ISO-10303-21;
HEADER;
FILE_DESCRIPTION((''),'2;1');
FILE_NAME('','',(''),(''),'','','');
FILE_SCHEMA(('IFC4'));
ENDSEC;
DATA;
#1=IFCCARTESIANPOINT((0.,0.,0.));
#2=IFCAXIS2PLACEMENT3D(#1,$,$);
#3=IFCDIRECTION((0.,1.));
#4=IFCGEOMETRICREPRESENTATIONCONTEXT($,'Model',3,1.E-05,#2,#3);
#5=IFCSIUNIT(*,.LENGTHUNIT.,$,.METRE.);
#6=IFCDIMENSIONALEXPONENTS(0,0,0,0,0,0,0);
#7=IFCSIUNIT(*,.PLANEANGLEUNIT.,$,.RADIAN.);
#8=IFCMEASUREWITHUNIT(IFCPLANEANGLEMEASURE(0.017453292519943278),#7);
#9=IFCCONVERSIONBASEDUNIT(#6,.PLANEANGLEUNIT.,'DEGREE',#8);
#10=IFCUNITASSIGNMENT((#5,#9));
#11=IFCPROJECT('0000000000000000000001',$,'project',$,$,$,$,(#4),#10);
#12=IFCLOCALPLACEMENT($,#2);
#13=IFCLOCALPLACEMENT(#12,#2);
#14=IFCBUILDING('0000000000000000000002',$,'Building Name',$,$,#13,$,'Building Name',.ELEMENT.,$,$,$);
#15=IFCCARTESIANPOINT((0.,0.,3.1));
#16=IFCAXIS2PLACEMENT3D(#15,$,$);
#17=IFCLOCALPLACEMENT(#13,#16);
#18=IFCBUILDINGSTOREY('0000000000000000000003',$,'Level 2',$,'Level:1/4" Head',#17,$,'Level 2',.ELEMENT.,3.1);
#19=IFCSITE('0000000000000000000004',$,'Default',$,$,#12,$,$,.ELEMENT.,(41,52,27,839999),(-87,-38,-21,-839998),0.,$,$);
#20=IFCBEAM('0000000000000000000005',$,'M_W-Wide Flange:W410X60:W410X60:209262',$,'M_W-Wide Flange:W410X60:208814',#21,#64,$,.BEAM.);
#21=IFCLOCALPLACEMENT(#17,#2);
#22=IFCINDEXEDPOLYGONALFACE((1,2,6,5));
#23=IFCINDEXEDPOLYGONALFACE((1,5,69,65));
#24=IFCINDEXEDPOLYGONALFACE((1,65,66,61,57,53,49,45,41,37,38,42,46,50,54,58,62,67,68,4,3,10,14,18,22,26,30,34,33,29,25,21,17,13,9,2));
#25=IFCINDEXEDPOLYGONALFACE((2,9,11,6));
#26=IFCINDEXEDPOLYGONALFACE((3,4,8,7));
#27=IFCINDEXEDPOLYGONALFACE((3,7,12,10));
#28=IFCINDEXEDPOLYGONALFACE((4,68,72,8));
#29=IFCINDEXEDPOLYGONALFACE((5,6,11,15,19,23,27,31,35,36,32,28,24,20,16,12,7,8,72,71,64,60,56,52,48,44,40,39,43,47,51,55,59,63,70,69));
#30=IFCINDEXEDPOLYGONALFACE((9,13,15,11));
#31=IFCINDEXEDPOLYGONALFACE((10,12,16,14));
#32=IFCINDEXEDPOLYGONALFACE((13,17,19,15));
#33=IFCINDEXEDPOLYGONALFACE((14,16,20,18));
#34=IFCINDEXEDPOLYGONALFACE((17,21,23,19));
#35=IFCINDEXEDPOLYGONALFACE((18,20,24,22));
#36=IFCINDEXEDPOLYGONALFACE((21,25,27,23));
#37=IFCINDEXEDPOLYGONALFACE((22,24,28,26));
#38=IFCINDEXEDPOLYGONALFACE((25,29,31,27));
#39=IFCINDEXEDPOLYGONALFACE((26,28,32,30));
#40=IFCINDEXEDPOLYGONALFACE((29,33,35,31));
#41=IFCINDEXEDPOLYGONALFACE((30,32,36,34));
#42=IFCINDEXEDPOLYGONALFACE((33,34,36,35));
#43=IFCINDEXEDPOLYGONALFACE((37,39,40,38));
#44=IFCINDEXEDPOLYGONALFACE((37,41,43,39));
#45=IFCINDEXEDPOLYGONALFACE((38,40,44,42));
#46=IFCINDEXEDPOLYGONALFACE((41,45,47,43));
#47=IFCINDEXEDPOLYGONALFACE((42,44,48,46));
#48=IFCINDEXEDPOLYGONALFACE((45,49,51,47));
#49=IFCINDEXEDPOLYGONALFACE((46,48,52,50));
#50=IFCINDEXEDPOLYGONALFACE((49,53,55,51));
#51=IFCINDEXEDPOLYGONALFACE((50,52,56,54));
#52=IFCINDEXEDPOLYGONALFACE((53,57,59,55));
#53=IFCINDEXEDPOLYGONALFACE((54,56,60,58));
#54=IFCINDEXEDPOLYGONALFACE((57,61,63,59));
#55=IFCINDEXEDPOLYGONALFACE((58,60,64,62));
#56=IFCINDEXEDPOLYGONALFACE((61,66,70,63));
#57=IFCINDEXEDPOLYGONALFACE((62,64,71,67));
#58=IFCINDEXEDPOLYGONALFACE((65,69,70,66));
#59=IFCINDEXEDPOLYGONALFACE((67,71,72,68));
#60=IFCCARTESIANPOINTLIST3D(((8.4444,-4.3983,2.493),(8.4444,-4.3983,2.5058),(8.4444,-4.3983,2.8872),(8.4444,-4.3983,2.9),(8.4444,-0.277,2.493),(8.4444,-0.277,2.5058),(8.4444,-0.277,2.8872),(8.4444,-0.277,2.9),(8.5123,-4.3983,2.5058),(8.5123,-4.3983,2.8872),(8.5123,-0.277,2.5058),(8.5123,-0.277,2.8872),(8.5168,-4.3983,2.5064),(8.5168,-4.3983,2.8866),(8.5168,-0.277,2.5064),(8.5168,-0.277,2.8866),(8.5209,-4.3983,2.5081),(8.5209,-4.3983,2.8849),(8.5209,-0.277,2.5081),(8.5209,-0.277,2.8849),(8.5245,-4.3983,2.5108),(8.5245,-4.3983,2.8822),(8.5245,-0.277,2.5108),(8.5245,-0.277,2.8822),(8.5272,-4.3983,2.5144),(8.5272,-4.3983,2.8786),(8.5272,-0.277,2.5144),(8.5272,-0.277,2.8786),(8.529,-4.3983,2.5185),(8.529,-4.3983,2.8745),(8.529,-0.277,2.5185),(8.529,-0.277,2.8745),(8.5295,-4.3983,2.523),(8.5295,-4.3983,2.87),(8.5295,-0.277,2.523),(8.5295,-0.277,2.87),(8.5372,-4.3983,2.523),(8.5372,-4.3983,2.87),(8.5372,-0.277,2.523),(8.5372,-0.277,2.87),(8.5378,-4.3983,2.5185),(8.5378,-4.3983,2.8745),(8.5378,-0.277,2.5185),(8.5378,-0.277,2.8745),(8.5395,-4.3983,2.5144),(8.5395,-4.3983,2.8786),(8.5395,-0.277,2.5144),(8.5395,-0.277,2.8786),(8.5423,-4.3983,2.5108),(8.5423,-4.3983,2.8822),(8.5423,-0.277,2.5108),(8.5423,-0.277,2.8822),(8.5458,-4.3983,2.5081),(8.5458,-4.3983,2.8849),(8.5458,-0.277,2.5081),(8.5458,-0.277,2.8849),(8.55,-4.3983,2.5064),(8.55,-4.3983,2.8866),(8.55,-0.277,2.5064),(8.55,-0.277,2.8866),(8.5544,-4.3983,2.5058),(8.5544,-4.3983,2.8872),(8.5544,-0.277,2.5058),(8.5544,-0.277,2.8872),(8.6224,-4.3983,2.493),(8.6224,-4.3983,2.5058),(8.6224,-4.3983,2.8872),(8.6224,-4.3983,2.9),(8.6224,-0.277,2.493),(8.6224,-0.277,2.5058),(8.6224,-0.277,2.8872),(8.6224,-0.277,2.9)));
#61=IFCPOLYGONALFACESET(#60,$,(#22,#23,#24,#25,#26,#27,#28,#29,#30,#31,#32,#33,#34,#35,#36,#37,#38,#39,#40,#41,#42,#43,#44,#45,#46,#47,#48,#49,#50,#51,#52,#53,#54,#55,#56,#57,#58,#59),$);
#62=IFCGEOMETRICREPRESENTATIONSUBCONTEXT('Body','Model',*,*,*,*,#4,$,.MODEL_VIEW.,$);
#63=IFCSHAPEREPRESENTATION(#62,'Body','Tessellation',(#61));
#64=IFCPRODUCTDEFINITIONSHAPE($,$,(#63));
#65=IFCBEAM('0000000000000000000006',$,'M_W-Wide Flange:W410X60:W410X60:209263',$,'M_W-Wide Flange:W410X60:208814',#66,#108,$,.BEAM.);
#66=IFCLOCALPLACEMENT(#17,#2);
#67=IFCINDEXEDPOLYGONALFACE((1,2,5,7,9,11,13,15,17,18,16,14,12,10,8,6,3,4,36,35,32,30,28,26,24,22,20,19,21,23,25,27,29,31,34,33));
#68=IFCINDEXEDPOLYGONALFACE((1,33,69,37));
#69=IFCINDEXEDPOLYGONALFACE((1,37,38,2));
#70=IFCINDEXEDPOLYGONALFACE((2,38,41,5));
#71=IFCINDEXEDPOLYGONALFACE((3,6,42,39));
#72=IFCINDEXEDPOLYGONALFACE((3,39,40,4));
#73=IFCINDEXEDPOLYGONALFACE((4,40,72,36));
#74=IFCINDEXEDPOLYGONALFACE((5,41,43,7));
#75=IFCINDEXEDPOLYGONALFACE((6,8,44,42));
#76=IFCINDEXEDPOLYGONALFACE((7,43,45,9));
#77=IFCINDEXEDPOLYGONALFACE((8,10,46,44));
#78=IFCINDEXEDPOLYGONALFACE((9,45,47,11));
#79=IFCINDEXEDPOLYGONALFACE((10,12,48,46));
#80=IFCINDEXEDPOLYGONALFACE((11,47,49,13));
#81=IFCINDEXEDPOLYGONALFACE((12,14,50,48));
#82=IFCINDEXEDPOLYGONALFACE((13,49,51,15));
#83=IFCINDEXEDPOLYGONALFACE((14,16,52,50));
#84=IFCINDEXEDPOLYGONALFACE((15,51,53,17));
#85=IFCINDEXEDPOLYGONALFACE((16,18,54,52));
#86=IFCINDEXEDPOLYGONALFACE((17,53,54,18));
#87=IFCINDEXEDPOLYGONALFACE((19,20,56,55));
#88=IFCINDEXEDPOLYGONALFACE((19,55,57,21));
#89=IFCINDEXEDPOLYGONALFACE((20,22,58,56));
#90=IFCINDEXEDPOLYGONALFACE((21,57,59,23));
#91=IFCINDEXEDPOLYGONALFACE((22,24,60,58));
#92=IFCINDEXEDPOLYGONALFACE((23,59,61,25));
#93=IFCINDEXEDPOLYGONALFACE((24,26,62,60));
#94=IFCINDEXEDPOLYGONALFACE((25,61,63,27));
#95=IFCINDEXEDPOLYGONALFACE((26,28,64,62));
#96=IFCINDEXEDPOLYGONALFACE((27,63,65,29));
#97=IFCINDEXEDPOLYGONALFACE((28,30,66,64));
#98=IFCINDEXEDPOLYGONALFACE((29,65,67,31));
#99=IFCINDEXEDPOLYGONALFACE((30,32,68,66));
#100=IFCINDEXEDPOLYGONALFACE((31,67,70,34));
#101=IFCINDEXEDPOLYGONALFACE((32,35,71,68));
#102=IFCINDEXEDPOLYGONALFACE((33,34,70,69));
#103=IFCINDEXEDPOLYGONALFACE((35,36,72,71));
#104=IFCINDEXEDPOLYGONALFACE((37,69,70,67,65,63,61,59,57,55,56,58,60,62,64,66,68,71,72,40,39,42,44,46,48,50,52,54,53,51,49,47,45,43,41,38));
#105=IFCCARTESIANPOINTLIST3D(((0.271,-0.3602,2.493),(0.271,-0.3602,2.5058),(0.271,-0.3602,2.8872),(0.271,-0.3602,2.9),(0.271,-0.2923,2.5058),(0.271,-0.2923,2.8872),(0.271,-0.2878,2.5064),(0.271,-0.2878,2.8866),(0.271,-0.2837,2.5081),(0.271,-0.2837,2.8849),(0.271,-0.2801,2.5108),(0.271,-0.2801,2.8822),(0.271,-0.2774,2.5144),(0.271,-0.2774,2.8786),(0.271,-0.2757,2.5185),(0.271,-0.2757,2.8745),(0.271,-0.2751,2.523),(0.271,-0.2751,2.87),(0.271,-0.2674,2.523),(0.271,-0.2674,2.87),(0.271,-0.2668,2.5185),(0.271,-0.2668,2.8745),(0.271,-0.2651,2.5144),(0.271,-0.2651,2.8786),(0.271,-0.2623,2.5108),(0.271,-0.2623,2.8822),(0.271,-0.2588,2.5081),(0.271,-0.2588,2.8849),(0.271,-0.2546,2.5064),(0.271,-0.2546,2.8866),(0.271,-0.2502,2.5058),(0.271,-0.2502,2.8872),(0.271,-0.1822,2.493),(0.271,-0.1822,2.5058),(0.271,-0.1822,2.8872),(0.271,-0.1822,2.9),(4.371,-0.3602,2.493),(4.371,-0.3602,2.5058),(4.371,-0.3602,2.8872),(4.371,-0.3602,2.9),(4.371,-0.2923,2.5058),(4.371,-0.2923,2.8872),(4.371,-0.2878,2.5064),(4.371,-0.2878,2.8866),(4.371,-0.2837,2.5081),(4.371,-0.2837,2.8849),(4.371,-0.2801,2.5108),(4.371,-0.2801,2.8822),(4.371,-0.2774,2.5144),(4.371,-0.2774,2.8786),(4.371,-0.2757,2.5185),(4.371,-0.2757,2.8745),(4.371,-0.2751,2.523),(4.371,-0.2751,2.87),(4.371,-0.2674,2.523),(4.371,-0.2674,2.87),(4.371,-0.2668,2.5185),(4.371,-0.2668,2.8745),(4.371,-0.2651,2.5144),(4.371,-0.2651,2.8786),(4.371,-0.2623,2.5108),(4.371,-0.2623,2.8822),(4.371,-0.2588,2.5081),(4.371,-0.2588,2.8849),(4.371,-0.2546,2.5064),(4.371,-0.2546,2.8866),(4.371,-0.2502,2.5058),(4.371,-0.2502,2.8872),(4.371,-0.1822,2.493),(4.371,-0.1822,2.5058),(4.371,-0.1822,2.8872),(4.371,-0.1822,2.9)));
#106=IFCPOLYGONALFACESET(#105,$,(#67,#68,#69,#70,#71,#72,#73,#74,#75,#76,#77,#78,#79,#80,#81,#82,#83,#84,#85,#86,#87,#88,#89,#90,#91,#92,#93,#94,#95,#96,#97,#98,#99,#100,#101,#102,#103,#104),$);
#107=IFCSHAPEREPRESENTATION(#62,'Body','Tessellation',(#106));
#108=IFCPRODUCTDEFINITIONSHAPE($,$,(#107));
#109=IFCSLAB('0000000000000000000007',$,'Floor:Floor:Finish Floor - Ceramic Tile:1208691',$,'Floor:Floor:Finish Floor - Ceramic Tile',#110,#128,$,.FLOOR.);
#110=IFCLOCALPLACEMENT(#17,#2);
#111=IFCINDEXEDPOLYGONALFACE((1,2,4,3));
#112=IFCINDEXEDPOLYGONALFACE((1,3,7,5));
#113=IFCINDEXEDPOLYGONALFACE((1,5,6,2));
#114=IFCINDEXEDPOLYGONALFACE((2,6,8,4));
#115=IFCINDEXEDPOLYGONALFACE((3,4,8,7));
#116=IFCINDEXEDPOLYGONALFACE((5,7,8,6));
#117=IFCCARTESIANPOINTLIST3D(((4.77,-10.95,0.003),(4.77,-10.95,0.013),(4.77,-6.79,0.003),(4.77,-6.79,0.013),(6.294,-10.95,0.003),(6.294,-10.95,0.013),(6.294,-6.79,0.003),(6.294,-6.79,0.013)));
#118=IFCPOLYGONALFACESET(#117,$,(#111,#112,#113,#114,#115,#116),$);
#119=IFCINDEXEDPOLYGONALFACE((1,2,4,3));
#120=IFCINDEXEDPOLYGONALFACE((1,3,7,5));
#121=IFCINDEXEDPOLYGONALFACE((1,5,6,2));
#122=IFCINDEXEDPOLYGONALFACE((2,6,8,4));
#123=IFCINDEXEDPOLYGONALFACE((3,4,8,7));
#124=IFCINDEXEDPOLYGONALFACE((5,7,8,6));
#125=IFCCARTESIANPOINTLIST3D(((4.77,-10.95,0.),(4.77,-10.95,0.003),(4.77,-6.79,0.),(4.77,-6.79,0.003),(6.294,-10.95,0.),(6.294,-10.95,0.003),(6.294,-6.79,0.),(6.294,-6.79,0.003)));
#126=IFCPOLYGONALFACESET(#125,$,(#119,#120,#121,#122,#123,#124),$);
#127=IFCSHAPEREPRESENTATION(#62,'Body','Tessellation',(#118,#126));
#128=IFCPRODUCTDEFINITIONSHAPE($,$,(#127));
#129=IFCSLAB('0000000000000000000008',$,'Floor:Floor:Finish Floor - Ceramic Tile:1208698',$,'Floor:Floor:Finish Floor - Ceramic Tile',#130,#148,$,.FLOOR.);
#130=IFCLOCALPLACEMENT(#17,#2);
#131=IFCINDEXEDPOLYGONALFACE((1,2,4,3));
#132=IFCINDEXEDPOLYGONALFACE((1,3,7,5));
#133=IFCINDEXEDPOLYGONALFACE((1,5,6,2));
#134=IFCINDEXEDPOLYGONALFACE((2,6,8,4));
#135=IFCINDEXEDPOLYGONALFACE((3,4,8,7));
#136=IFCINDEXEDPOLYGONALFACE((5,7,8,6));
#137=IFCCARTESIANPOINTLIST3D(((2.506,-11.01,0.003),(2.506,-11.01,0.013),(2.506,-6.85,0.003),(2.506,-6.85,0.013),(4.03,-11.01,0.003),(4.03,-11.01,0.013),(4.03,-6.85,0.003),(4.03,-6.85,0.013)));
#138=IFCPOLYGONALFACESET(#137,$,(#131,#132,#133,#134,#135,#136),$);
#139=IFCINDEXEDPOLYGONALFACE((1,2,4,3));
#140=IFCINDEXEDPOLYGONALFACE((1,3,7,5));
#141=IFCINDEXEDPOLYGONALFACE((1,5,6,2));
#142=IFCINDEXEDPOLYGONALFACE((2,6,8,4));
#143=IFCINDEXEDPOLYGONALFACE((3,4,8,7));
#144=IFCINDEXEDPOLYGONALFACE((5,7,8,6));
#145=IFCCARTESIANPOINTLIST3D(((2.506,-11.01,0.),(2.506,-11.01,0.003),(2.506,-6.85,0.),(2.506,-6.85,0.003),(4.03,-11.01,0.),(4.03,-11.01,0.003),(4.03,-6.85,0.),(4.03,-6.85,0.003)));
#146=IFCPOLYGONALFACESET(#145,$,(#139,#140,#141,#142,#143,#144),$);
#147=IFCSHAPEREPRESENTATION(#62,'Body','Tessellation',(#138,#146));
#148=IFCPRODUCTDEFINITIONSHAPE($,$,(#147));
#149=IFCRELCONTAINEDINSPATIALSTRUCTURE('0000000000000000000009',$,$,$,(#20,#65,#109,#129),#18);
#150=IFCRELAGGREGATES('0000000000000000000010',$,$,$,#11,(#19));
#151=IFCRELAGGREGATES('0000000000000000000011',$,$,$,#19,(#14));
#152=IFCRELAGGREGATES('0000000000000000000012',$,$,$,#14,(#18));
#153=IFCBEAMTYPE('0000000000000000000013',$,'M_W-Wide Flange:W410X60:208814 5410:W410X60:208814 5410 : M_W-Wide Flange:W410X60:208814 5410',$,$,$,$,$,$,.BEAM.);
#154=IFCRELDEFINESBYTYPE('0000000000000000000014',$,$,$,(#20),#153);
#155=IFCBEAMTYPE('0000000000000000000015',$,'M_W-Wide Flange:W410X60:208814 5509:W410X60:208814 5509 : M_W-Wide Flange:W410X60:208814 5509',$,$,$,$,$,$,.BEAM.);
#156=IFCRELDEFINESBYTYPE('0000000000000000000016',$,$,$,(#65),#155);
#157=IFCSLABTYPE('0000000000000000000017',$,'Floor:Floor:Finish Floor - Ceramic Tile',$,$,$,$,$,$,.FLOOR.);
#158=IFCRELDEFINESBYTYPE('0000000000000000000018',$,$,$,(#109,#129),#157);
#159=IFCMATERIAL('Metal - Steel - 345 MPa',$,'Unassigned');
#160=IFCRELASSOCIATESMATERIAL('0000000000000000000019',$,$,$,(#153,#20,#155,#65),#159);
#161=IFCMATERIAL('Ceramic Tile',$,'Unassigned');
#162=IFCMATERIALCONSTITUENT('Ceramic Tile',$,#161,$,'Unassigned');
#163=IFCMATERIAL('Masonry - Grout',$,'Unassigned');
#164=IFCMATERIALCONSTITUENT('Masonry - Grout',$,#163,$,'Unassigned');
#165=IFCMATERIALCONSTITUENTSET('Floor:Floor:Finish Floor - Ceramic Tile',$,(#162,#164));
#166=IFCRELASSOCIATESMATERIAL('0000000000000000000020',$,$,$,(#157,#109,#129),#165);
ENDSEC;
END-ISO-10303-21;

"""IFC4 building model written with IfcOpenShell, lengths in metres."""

from ifc_helpers import new_model, entity, si_unit, converted_unit, direction, frame, origin, place, context, subcontext, project, spatial, line, arc, indexed_curve, outline, extrude, source, transform, mapped, material, constituent, constituent_set, type_object, type_shapes, element, save


model = new_model("IFC4")

# Units and contexts
model_context = context("Model", 3, precision=1e-05, world=origin(), true_north=direction((0.0, 1.0)))
body_context = subcontext(model_context, "Body", "Model", "MODEL_VIEW")
ifc_project = project(units=[si_unit("LENGTHUNIT", "METRE"), converted_unit("PLANEANGLEUNIT", "DEGREE", entity("IfcPlaneAngleMeasure", 0.017453292519943278), si_unit("PLANEANGLEUNIT", "RADIAN"), dimensions=[0, 0, 0, 0, 0, 0, 0])], contexts=[model_context])

# Site, building, storey
site_placement = place(None, origin())
site = spatial("IfcSite", under=ifc_project, at=site_placement, Name="Default", CompositionType="ELEMENT", RefLatitude=(41, 52, 27, 839999), RefLongitude=(-87, -38, -21, -839998), RefElevation=0.0)
building_placement = place(site_placement, origin())
building = spatial("IfcBuilding", under=site, at=building_placement, Name="Building Name", LongName="Building Name", CompositionType="ELEMENT")
storey_placement = place(building_placement, frame((0.0, 0.0, 3.1)))
storey = spatial("IfcBuildingStorey", under=building, at=storey_placement, Name="Level 2", ObjectType="Level:1/4\" Head", LongName="Level 2", CompositionType="ELEMENT", Elevation=3.1)

# Beams
ifc_material_1 = material(Name="Metal - Steel - 345 MPa", Category="Unassigned")
beam_type_1 = type_object("IfcBeamType", Name="M_W-Wide Flange:W410X60:208814 5410:W410X60:208814 5410 : M_W-Wide Flange:W410X60:208814 5410", PredefinedType="BEAM", material=ifc_material_1)
shared_shape_1 = source(origin(), body_context, "Body", "SweptSolid", [
    extrude(outline(indexed_curve([(-0.0211, -0.1907), (-0.089, -0.1907), (-0.089, -0.2035), (0.089, -0.2035), (0.089, -0.1907), (0.021, -0.1907), (0.0089, -0.1857), (0.0038, -0.1735), (0.0039, 0.1735), (0.0089, 0.1857), (0.0211, 0.1907), (0.089, 0.1907), (0.089, 0.2035), (-0.089, 0.2035), (-0.089, 0.1907), (-0.021, 0.1907), (-0.0089, 0.1857), (-0.0038, 0.1735), (-0.0039, -0.1735), (-0.0089, -0.1857)], segments=[line(1, 2, 3, 4, 5, 6), arc(6, 7, 8), line(8, 9), arc(9, 10, 11), line(11, 12, 13, 14, 15, 16), arc(16, 17, 18), line(18, 19), arc(19, 20, 1)], self_intersect=False)), frame((0.0, 0.0, -0.2035), z_axis=(0.0, -1.0, 0.0), x_axis=(1.0, 0.0, 0.0)), (0.0, 0.0, -1.0), 4.1213),
])
type_shapes(beam_type_1, [shared_shape_1])
beam_1_placement = place(storey_placement, frame((8.5334, -4.3983, 2.9)))
element("IfcBeam", 1, at=beam_1_placement, inside=storey, type_object=beam_type_1, material=ifc_material_1, Name="M_W-Wide Flange:W410X60:W410X60:209262", ObjectType="M_W-Wide Flange:W410X60:208814", PredefinedType="BEAM", context=body_context, shape_type="MappedRepresentation", body=[
    mapped(shared_shape_1, transform((0.0, 0.0, 0.0), scale=1.0)),
])
beam_type_2 = type_object("IfcBeamType", Name="M_W-Wide Flange:W410X60:208814 5509:W410X60:208814 5509 : M_W-Wide Flange:W410X60:208814 5509", PredefinedType="BEAM", material=ifc_material_1)
shared_shape_2 = source(origin(), body_context, "Body", "SweptSolid", [
    extrude(outline(indexed_curve([(-0.2035, -0.089), (-0.1907, -0.089), (-0.1907, -0.0211), (-0.1857, -0.0089), (-0.1735, -0.0039), (0.1735, -0.0039), (0.1857, -0.0089), (0.1907, -0.0211), (0.1907, -0.089), (0.2035, -0.089), (0.2035, 0.089), (0.1907, 0.089), (0.1907, 0.021), (0.1857, 0.0089), (0.1735, 0.0038), (-0.1735, 0.0038), (-0.1857, 0.0089), (-0.1907, 0.021), (-0.1907, 0.089), (-0.2035, 0.089)], segments=[line(1, 2, 3), arc(3, 4, 5), line(5, 6), arc(6, 7, 8), line(8, 9, 10, 11, 12, 13), arc(13, 14, 15), line(15, 16), arc(16, 17, 18), line(18, 19, 20, 1)], self_intersect=False)), frame((0.0, 0.0, -0.2035), z_axis=(0.0, 1.0, 0.0), x_axis=(0.0, 0.0, 1.0)), (0.0, 0.0, 1.0), 4.1),
])
type_shapes(beam_type_2, [shared_shape_2])
beam_2_placement = place(storey_placement, frame((4.371, -0.2712, 2.9), z_axis=(0.0, 0.0, 1.0), x_axis=(0.0, 1.0, 0.0)))
element("IfcBeam", 2, at=beam_2_placement, inside=storey, type_object=beam_type_2, material=ifc_material_1, Name="M_W-Wide Flange:W410X60:W410X60:209263", ObjectType="M_W-Wide Flange:W410X60:208814", PredefinedType="BEAM", context=body_context, shape_type="MappedRepresentation", body=[
    mapped(shared_shape_2, transform((0.0, 0.0, 0.0), scale=1.0)),
])

# Slabs
ifc_material_2 = material(Name="Ceramic Tile", Category="Unassigned")
ifc_constituent_1 = constituent(ifc_material_2, Name="Ceramic Tile", Category="Unassigned")
ifc_material_3 = material(Name="Masonry - Grout", Category="Unassigned")
ifc_constituent_2 = constituent(ifc_material_3, Name="Masonry - Grout", Category="Unassigned")
ifc_constituent_set_1 = constituent_set(constituents=[ifc_constituent_1, ifc_constituent_2], Name="Floor:Floor:Finish Floor - Ceramic Tile")
slab_type_1 = type_object("IfcSlabType", Name="Floor:Floor:Finish Floor - Ceramic Tile", PredefinedType="FLOOR", material=ifc_constituent_set_1)
slab_1_placement = place(storey_placement, origin())
element("IfcSlab", 3, at=slab_1_placement, inside=storey, type_object=slab_type_1, material=ifc_constituent_set_1, Name="Floor:Floor:Finish Floor - Ceramic Tile:1208691", ObjectType="Floor:Floor:Finish Floor - Ceramic Tile", PredefinedType="FLOOR", context=body_context, shape_type="SweptSolid", body=[
    extrude(outline(indexed_curve([(-2.08, -0.762), (2.08, -0.762), (2.08, 0.762), (-2.08, 0.762), (-2.08, -0.762)], self_intersect=False)), frame((5.532, -8.87, 0.003), z_axis=(0.0, 0.0, 1.0), x_axis=(0.0, 1.0, 0.0)), (0.0, 0.0, 1.0), 0.01),
    extrude(outline(indexed_curve([(-2.08, -0.762), (2.08, -0.762), (2.08, 0.762), (-2.08, 0.762), (-2.08, -0.762)], self_intersect=False)), frame((5.532, -8.87, 0.0), z_axis=(0.0, 0.0, 1.0), x_axis=(0.0, 1.0, 0.0)), (0.0, 0.0, 1.0), 0.003),
])
slab_2_placement = place(storey_placement, origin())
element("IfcSlab", 4, at=slab_2_placement, inside=storey, type_object=slab_type_1, material=ifc_constituent_set_1, Name="Floor:Floor:Finish Floor - Ceramic Tile:1208698", ObjectType="Floor:Floor:Finish Floor - Ceramic Tile", PredefinedType="FLOOR", context=body_context, shape_type="SweptSolid", body=[
    extrude(outline(indexed_curve([(-2.08, -0.762), (2.08, -0.762), (2.08, 0.762), (-2.08, 0.762), (-2.08, -0.762)], self_intersect=False)), frame((3.268, -8.93, 0.003), z_axis=(0.0, 0.0, 1.0), x_axis=(0.0, 1.0, 0.0)), (0.0, 0.0, 1.0), 0.01),
    extrude(outline(indexed_curve([(-2.08, -0.762), (2.08, -0.762), (2.08, 0.762), (-2.08, 0.762), (-2.08, -0.762)], self_intersect=False)), frame((3.268, -8.93, 0.0), z_axis=(0.0, 0.0, 1.0), x_axis=(0.0, 1.0, 0.0)), (0.0, 0.0, 1.0), 0.003),
])

save(model, "model.ifc")
